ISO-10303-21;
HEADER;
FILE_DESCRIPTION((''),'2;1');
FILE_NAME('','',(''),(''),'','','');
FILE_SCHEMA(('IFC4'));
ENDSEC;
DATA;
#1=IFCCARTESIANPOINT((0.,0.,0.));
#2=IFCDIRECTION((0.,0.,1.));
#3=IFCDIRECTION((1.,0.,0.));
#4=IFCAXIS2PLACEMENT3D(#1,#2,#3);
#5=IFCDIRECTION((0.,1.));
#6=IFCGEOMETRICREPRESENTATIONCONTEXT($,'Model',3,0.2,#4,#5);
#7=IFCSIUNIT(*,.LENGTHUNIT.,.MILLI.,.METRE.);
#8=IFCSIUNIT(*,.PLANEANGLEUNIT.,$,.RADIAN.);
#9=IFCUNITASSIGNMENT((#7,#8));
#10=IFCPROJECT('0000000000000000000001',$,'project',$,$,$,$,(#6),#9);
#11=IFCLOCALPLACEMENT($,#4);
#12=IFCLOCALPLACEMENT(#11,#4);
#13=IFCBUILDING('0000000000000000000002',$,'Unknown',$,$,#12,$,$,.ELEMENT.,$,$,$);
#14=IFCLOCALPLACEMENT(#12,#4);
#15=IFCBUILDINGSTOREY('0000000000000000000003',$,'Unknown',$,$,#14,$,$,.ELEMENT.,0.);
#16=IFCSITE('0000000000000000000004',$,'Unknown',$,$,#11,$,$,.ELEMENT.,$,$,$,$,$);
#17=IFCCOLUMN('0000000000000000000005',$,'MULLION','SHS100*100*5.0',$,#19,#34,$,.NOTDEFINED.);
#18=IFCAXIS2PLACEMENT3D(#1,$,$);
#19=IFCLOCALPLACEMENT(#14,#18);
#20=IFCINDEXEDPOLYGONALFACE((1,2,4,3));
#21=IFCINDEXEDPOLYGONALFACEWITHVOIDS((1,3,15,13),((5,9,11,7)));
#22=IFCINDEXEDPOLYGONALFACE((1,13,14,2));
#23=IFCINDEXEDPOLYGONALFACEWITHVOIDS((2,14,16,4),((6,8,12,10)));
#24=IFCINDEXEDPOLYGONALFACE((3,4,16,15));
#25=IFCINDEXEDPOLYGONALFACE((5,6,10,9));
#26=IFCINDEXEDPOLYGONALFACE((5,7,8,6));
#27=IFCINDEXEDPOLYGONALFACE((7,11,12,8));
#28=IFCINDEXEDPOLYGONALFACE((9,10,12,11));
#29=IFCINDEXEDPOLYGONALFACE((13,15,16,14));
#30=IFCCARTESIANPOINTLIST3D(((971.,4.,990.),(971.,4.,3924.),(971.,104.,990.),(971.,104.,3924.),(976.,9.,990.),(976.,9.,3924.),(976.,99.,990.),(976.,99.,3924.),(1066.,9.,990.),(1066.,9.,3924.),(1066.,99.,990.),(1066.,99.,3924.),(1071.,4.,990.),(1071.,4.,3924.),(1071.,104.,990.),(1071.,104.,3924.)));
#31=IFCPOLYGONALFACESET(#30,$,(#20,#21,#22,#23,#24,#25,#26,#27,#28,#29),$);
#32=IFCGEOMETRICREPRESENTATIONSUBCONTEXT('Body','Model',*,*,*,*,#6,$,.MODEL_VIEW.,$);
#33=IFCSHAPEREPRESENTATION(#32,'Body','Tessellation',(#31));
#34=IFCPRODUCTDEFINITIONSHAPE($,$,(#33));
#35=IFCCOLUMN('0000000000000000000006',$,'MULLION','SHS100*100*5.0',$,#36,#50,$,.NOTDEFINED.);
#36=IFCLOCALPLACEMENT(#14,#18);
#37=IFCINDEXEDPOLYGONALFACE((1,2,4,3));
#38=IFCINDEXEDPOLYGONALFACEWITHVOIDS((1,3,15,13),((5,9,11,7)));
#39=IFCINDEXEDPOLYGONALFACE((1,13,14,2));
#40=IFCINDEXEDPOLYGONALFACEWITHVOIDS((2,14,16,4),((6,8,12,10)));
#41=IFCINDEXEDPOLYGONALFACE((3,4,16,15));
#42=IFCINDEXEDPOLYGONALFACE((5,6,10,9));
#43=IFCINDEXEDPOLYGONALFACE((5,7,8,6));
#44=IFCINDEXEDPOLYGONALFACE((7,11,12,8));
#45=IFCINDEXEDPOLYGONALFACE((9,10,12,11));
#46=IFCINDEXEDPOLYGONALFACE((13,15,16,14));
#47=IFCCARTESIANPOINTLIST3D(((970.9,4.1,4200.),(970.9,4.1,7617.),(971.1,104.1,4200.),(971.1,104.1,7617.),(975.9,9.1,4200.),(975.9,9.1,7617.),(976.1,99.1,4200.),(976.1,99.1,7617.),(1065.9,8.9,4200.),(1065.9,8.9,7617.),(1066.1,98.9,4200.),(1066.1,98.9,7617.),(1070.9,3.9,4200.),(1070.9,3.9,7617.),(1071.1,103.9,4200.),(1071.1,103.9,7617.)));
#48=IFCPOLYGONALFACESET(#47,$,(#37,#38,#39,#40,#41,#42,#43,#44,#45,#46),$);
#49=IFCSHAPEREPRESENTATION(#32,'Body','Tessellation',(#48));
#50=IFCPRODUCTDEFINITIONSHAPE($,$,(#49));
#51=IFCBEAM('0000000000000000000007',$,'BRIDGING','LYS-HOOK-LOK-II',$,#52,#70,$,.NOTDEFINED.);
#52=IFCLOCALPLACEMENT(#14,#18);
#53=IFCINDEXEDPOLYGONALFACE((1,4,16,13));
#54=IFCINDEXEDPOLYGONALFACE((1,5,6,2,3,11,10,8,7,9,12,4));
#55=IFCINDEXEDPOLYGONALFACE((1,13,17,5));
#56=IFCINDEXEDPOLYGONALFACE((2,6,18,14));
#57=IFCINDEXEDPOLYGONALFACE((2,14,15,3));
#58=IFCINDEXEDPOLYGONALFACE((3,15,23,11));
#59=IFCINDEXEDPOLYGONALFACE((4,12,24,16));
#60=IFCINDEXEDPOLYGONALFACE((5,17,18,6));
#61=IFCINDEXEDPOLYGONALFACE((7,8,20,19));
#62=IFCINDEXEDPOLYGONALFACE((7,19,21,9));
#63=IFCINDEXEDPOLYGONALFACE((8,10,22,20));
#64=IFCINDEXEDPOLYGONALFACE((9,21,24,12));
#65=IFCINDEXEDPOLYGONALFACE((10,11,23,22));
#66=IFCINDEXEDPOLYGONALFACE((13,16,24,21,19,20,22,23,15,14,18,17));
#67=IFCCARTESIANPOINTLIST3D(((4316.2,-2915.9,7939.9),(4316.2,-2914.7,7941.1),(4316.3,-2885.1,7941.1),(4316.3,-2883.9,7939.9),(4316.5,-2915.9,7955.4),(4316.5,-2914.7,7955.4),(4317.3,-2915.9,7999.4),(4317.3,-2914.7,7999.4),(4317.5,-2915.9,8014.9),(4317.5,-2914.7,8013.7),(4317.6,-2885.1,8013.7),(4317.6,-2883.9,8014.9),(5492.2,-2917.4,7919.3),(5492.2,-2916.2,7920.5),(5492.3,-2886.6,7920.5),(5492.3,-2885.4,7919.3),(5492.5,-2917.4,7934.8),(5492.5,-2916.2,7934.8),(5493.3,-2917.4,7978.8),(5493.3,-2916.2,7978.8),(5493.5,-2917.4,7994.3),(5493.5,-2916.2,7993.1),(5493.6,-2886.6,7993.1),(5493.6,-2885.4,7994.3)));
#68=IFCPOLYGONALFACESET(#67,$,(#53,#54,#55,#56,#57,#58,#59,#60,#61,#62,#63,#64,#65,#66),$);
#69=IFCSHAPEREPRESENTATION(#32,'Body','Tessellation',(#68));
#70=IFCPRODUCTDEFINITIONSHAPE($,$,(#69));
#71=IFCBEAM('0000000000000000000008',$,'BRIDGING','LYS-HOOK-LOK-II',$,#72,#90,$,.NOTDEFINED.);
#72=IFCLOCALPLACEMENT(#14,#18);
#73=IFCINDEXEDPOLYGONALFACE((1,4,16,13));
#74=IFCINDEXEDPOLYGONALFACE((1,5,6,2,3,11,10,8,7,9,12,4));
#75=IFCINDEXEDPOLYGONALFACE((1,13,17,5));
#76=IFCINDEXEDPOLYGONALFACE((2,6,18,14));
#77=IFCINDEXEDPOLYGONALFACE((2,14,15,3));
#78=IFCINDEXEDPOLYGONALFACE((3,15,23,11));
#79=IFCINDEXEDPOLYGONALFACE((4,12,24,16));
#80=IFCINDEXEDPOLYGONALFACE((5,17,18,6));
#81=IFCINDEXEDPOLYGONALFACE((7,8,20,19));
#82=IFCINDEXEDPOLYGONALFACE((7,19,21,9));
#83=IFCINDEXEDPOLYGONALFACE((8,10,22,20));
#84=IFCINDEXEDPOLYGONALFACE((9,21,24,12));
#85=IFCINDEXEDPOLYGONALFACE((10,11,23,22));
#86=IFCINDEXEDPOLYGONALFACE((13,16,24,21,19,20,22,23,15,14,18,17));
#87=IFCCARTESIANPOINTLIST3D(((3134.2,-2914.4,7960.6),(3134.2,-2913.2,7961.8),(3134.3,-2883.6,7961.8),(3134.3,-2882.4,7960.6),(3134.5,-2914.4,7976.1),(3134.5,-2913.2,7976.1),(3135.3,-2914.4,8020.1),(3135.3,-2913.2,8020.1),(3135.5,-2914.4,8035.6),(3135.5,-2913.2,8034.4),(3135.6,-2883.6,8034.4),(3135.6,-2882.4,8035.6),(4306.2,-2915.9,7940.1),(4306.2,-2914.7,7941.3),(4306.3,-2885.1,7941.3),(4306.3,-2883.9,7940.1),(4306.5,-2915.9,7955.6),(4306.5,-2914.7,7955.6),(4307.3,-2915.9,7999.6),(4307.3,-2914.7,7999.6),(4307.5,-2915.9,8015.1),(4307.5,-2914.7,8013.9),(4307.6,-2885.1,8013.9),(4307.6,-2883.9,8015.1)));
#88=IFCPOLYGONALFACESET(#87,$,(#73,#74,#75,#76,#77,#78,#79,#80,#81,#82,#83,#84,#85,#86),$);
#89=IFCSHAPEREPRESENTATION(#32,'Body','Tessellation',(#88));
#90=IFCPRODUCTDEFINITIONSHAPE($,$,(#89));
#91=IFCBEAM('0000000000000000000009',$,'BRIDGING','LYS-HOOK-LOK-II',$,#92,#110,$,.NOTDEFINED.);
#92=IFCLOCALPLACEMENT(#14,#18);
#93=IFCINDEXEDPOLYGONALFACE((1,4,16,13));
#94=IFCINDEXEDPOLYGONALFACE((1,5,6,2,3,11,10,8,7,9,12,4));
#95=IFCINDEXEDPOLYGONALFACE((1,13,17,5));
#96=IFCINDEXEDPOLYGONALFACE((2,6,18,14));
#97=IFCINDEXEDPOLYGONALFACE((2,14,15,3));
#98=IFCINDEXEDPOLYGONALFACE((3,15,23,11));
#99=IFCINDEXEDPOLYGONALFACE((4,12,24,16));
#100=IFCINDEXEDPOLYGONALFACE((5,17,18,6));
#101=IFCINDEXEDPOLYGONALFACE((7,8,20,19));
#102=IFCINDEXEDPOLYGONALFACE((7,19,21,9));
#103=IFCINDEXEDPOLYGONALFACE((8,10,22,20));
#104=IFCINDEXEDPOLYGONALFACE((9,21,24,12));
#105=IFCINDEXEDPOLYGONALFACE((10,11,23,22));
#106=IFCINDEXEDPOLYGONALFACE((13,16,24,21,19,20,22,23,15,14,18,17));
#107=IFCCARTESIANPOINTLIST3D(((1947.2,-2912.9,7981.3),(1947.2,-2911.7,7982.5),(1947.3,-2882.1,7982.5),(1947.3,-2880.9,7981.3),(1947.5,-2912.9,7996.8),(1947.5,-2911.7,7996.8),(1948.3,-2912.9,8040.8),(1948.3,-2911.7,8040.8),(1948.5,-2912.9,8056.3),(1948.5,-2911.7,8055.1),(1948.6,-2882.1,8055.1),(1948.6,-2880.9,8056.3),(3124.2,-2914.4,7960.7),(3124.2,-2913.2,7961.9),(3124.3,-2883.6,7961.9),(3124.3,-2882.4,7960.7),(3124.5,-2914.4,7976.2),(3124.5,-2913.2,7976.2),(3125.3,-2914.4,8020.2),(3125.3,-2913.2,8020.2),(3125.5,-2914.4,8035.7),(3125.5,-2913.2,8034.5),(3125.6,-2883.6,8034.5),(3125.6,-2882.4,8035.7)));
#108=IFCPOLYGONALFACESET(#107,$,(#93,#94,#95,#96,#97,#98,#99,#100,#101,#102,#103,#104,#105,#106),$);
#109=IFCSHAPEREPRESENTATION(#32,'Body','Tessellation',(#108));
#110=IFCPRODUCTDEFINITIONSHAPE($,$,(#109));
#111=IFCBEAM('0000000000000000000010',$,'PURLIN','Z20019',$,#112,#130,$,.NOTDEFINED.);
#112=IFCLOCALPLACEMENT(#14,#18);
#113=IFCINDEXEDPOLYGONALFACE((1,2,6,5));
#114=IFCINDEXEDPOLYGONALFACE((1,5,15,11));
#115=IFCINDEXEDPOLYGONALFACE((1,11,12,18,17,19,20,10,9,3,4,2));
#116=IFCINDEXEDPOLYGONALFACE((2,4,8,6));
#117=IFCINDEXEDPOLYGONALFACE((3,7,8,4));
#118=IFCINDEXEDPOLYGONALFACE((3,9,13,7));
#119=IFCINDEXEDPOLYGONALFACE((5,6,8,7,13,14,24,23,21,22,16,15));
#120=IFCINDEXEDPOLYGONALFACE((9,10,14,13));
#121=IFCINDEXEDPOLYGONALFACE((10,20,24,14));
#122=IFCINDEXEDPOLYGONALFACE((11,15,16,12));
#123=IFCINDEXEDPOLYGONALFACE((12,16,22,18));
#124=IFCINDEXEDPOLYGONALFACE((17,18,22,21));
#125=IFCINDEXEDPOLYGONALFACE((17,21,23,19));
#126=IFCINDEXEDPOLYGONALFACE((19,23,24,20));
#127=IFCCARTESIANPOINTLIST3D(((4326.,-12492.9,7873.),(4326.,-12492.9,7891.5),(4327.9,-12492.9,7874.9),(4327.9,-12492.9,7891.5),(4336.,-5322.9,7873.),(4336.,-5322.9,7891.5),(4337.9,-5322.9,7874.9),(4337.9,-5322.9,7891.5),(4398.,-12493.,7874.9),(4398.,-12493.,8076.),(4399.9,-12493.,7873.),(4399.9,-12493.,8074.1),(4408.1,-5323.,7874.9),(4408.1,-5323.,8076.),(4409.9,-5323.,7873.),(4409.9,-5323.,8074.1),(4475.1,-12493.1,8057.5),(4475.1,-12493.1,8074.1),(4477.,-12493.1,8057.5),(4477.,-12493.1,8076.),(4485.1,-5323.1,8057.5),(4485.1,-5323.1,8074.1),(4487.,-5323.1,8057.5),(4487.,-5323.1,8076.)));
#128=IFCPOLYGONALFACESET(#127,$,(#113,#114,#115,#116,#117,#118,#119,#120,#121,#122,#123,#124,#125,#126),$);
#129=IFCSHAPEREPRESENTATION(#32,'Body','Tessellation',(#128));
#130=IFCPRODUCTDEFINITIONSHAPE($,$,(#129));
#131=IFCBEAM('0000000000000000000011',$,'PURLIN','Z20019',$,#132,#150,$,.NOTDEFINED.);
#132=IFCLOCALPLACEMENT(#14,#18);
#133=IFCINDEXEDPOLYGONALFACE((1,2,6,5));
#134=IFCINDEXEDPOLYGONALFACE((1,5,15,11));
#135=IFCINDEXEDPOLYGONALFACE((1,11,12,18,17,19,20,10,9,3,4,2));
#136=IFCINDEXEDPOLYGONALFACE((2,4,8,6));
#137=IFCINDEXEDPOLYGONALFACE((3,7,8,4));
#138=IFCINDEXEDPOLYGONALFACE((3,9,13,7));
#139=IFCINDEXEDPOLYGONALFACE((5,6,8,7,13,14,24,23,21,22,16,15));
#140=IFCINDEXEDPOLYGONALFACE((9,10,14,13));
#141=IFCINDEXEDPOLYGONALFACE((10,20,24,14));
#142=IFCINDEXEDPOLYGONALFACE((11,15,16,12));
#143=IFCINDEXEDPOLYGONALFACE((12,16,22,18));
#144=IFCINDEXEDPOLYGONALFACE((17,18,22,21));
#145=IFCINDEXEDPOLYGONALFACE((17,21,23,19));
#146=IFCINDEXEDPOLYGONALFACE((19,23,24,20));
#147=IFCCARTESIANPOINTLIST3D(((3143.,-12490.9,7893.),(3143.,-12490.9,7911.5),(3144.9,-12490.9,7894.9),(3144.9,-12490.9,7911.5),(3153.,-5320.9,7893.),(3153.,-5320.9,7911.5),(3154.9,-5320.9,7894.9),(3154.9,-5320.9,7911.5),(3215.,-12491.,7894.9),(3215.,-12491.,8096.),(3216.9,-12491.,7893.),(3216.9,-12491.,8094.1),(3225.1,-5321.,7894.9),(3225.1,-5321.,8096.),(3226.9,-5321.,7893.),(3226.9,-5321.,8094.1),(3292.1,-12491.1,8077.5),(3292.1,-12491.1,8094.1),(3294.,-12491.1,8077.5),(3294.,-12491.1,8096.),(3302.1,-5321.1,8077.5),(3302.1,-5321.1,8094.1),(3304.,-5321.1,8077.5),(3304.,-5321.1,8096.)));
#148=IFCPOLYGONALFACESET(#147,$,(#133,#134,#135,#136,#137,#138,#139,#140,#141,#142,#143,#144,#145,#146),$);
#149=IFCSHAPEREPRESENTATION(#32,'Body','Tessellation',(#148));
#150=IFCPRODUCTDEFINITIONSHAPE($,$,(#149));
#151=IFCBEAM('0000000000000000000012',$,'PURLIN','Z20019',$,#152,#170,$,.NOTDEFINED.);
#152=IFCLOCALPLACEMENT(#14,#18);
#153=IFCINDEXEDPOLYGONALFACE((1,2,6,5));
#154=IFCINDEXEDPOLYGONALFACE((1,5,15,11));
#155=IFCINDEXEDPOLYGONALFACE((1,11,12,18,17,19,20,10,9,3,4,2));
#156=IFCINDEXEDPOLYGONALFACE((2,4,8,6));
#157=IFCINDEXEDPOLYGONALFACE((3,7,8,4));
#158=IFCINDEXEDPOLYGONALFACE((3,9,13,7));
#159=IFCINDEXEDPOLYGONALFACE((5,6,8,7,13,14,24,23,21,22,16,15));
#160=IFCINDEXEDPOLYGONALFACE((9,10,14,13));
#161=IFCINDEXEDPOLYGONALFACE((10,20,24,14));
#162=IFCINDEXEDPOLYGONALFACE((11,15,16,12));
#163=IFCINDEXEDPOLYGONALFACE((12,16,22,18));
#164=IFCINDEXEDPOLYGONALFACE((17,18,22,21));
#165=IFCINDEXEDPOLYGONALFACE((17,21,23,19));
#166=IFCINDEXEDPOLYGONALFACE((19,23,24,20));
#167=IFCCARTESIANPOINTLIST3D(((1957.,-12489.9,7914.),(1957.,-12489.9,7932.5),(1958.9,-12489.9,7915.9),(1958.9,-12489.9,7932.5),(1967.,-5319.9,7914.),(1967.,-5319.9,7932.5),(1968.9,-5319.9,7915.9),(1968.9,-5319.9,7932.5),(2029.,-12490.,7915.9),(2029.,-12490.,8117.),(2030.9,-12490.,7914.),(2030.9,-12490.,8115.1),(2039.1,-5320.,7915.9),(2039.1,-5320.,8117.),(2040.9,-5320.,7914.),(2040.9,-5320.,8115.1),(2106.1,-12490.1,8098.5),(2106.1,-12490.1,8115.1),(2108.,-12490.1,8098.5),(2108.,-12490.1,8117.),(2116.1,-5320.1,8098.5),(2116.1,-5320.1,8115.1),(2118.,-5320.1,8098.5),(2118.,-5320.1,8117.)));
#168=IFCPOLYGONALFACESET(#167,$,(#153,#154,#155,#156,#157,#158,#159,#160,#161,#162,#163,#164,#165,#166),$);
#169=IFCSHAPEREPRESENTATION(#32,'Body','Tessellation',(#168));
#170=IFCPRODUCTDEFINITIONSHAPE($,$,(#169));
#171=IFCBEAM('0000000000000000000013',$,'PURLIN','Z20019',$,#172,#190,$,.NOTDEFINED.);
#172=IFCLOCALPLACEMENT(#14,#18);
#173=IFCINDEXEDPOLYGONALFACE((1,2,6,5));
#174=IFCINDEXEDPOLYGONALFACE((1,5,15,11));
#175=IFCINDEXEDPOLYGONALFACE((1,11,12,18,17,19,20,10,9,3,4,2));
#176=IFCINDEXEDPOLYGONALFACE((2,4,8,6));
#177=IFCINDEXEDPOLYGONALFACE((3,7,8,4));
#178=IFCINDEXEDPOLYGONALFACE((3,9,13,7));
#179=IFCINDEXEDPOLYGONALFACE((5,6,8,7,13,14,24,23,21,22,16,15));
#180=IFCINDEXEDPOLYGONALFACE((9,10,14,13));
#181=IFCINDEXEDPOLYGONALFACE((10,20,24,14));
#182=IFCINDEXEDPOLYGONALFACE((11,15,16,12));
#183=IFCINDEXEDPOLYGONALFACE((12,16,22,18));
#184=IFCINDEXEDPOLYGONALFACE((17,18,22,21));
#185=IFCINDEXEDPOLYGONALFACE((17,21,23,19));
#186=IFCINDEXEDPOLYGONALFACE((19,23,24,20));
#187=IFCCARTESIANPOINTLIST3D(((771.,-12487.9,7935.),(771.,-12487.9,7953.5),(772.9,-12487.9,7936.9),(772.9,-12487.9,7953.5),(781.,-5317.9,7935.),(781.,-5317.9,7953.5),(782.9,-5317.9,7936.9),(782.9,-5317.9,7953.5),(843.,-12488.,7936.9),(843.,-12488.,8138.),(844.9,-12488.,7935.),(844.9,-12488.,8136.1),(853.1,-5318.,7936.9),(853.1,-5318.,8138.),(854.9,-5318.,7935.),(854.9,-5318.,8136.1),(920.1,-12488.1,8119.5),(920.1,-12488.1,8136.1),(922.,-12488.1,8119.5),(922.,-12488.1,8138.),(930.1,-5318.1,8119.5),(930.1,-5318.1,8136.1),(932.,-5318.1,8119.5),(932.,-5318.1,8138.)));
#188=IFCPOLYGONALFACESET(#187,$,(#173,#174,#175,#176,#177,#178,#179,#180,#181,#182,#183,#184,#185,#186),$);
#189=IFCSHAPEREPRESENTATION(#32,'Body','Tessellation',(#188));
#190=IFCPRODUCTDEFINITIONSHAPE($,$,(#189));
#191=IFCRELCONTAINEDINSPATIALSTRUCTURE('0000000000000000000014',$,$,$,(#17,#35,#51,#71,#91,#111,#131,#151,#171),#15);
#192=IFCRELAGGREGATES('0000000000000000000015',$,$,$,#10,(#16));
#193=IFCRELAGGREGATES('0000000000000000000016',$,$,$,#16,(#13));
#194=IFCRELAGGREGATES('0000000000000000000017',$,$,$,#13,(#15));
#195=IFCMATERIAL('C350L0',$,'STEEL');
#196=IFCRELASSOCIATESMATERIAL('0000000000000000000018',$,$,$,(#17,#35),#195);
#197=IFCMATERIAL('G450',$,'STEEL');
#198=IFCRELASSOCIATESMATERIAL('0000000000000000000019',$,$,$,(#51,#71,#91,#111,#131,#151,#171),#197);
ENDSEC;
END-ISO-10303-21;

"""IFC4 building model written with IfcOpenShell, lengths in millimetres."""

from ifc_helpers import new_model, si_unit, direction, frame, origin_with_axes, place, context, subcontext, project, spatial, line, indexed_curve, outline, extrude, material, element, save


model = new_model("IFC4")

# Units and contexts
model_context = context("Model", 3, precision=0.2, world=origin_with_axes(), true_north=direction((0.0, 1.0)))
body_context = subcontext(model_context, "Body", "Model", "MODEL_VIEW")
ifc_project = project(units=[si_unit("LENGTHUNIT", "METRE", prefix="MILLI"), si_unit("PLANEANGLEUNIT", "RADIAN")], contexts=[model_context])

# Site, building, storey
site_placement = place(None, origin_with_axes())
site = spatial("IfcSite", under=ifc_project, at=site_placement, Name="Unknown", CompositionType="ELEMENT")
building_placement = place(site_placement, origin_with_axes())
building = spatial("IfcBuilding", under=site, at=building_placement, Name="Unknown", CompositionType="ELEMENT")
storey_placement = place(building_placement, origin_with_axes())
storey = spatial("IfcBuildingStorey", under=building, at=storey_placement, Name="Unknown", CompositionType="ELEMENT", Elevation=0.0)

# Columns
ifc_material_1 = material(Name="C350L0", Category="STEEL")
column_1_placement = place(storey_placement, frame((1021.0, 54.0, 990.0), z_axis=(0.000017, -1.0, 0.0), x_axis=(0.0, 0.0, 1.0)))
element("IfcColumn", 1, at=column_1_placement, inside=storey, material=ifc_material_1, Name="MULLION", Description="SHS100*100*5.0", PredefinedType="NOTDEFINED", context=body_context, shape_type="SolidModel", body=[
    extrude(outline(indexed_curve([(-50.0, -50.0), (50.0, -50.0), (50.0, 50.0), (-50.0, 50.0)], segments=[line(1, 2, 3, 4, 1)]), holes=[indexed_curve([(-45.0, -45.0), (-45.0, 45.0), (45.0, 45.0), (45.0, -45.0)], segments=[line(1, 2, 3, 4, 1)])]), frame((0.0, 0.0, 0.0), z_axis=(-1.0, 0.0, 0.0), x_axis=(0.0, 0.0, 1.0)), (0.0, 0.0, -1.0), 2934.0),
])
column_2_placement = place(storey_placement, frame((1021.0, 54.0, 4200.0), z_axis=(0.001396, 0.999999, 0.0), x_axis=(0.0, 0.0, 1.0)))
element("IfcColumn", 2, at=column_2_placement, inside=storey, material=ifc_material_1, Name="MULLION", Description="SHS100*100*5.0", PredefinedType="NOTDEFINED", context=body_context, shape_type="SolidModel", body=[
    extrude(outline(indexed_curve([(-50.0, -50.0), (50.0, -50.0), (50.0, 50.0), (-50.0, 50.0)], segments=[line(1, 2, 3, 4, 1)]), holes=[indexed_curve([(-45.0, -45.0), (-45.0, 45.0), (45.0, 45.0), (45.0, -45.0)], segments=[line(1, 2, 3, 4, 1)])]), frame((0.0, 0.0, 0.0), z_axis=(-1.0, 0.0, 0.0), x_axis=(0.0, 0.0, 1.0)), (0.0, 0.0, -1.0), 3417.0),
])

# Beams
ifc_material_2 = material(Name="G450", Category="STEEL")
beam_1_placement = place(storey_placement, frame((4316.9, -2899.9, 7977.4), z_axis=(-0.001276, -0.999999, 0.0), x_axis=(0.999846, -0.001275, -0.017514)))
element("IfcBeam", 3, at=beam_1_placement, inside=storey, material=ifc_material_2, Name="BRIDGING", Description="LYS-HOOK-LOK-II", PredefinedType="NOTDEFINED", context=body_context, shape_type="SolidModel", body=[
    extrude(outline(indexed_curve([(16.0, -37.5), (16.0, -22.0), (14.8, -22.0), (14.8, -36.3), (-14.8, -36.3), (-14.8, 36.3), (14.8, 36.3), (14.8, 22.0), (16.0, 22.0), (16.0, 37.5), (-16.0, 37.5), (-16.0, -37.5)], segments=[line(1, 2, 3, 4, 5, 6, 7, 8, 9, 10, 11, 12, 1)])), frame((0.0, 0.0, 0.0), z_axis=(-1.0, 0.0, 0.0), x_axis=(0.0, 0.0, 1.0)), (0.0, 0.0, -1.0), 1176.2),
])
beam_2_placement = place(storey_placement, frame((3134.9, -2898.4, 7998.1), z_axis=(-0.00128, -0.999999, 0.0), x_axis=(0.999846, -0.00128, -0.017489)))
element("IfcBeam", 4, at=beam_2_placement, inside=storey, material=ifc_material_2, Name="BRIDGING", Description="LYS-HOOK-LOK-II", PredefinedType="NOTDEFINED", context=body_context, shape_type="SolidModel", body=[
    extrude(outline(indexed_curve([(16.0, -37.5), (16.0, -22.0), (14.8, -22.0), (14.8, -36.3), (-14.8, -36.3), (-14.8, 36.3), (14.8, 36.3), (14.8, 22.0), (16.0, 22.0), (16.0, 37.5), (-16.0, 37.5), (-16.0, -37.5)], segments=[line(1, 2, 3, 4, 5, 6, 7, 8, 9, 10, 11, 12, 1)])), frame((0.0, 0.0, 0.0), z_axis=(-1.0, 0.0, 0.0), x_axis=(0.0, 0.0, 1.0)), (0.0, 0.0, -1.0), 1172.2),
])
beam_3_placement = place(storey_placement, frame((1947.9, -2896.9, 8018.8), z_axis=(-0.001274, -0.999999, 0.0), x_axis=(0.999846, -0.001274, -0.017499)))
element("IfcBeam", 5, at=beam_3_placement, inside=storey, material=ifc_material_2, Name="BRIDGING", Description="LYS-HOOK-LOK-II", PredefinedType="NOTDEFINED", context=body_context, shape_type="SolidModel", body=[
    extrude(outline(indexed_curve([(16.0, -37.5), (16.0, -22.0), (14.8, -22.0), (14.8, -36.3), (-14.8, -36.3), (-14.8, 36.3), (14.8, 36.3), (14.8, 22.0), (16.0, 22.0), (16.0, 37.5), (-16.0, 37.5), (-16.0, -37.5)], segments=[line(1, 2, 3, 4, 5, 6, 7, 8, 9, 10, 11, 12, 1)])), frame((0.0, 0.0, 0.0), z_axis=(-1.0, 0.0, 0.0), x_axis=(0.0, 0.0, 1.0)), (0.0, 0.0, -1.0), 1177.2),
])
for number, where, z_axis, x_axis, name in (
    (6, (4409.0, -5323.0, 7974.5), (-0.999999, 0.001395, 0.0), (-0.001395, -0.999999, 0.0), "PURLIN"),
    (7, (3226.0, -5321.0, 7994.5), (-0.999999, 0.001395, 0.0), (-0.001395, -0.999999, 0.0), "PURLIN"),
    (8, (2040.0, -5320.0, 8015.5), (-0.999999, 0.001395, 0.0), (-0.001395, -0.999999, 0.0), "PURLIN"),
    (9, (854.0, -5318.0, 8036.5), (-0.999999, 0.001395, 0.0), (-0.001395, -0.999999, 0.0), "PURLIN"),
):
    element("IfcBeam", number, at=place(storey_placement, frame(where, z_axis=z_axis, x_axis=x_axis)), inside=storey, material=ifc_material_2, Name=name, Description="Z20019", PredefinedType="NOTDEFINED", context=body_context, shape_type="SolidModel", body=[
        extrude(outline(indexed_curve([(73.0, -101.5), (73.0, -83.0), (71.2, -83.0), (71.2, -99.6), (0.9, -99.6), (0.9, 101.5), (-78.0, 101.5), (-78.0, 83.0), (-76.2, 83.0), (-76.2, 99.6), (-0.9, 99.6), (-0.9, -101.5)], segments=[line(1, 2, 3, 4, 5, 6, 7, 8, 9, 10, 11, 12, 1)])), frame((0.0, 0.0, 0.0), z_axis=(-1.0, 0.0, 0.0), x_axis=(0.0, 0.0, 1.0)), (0.0, 0.0, -1.0), 7170.0),
    ])

save(model, "model.ifc")
